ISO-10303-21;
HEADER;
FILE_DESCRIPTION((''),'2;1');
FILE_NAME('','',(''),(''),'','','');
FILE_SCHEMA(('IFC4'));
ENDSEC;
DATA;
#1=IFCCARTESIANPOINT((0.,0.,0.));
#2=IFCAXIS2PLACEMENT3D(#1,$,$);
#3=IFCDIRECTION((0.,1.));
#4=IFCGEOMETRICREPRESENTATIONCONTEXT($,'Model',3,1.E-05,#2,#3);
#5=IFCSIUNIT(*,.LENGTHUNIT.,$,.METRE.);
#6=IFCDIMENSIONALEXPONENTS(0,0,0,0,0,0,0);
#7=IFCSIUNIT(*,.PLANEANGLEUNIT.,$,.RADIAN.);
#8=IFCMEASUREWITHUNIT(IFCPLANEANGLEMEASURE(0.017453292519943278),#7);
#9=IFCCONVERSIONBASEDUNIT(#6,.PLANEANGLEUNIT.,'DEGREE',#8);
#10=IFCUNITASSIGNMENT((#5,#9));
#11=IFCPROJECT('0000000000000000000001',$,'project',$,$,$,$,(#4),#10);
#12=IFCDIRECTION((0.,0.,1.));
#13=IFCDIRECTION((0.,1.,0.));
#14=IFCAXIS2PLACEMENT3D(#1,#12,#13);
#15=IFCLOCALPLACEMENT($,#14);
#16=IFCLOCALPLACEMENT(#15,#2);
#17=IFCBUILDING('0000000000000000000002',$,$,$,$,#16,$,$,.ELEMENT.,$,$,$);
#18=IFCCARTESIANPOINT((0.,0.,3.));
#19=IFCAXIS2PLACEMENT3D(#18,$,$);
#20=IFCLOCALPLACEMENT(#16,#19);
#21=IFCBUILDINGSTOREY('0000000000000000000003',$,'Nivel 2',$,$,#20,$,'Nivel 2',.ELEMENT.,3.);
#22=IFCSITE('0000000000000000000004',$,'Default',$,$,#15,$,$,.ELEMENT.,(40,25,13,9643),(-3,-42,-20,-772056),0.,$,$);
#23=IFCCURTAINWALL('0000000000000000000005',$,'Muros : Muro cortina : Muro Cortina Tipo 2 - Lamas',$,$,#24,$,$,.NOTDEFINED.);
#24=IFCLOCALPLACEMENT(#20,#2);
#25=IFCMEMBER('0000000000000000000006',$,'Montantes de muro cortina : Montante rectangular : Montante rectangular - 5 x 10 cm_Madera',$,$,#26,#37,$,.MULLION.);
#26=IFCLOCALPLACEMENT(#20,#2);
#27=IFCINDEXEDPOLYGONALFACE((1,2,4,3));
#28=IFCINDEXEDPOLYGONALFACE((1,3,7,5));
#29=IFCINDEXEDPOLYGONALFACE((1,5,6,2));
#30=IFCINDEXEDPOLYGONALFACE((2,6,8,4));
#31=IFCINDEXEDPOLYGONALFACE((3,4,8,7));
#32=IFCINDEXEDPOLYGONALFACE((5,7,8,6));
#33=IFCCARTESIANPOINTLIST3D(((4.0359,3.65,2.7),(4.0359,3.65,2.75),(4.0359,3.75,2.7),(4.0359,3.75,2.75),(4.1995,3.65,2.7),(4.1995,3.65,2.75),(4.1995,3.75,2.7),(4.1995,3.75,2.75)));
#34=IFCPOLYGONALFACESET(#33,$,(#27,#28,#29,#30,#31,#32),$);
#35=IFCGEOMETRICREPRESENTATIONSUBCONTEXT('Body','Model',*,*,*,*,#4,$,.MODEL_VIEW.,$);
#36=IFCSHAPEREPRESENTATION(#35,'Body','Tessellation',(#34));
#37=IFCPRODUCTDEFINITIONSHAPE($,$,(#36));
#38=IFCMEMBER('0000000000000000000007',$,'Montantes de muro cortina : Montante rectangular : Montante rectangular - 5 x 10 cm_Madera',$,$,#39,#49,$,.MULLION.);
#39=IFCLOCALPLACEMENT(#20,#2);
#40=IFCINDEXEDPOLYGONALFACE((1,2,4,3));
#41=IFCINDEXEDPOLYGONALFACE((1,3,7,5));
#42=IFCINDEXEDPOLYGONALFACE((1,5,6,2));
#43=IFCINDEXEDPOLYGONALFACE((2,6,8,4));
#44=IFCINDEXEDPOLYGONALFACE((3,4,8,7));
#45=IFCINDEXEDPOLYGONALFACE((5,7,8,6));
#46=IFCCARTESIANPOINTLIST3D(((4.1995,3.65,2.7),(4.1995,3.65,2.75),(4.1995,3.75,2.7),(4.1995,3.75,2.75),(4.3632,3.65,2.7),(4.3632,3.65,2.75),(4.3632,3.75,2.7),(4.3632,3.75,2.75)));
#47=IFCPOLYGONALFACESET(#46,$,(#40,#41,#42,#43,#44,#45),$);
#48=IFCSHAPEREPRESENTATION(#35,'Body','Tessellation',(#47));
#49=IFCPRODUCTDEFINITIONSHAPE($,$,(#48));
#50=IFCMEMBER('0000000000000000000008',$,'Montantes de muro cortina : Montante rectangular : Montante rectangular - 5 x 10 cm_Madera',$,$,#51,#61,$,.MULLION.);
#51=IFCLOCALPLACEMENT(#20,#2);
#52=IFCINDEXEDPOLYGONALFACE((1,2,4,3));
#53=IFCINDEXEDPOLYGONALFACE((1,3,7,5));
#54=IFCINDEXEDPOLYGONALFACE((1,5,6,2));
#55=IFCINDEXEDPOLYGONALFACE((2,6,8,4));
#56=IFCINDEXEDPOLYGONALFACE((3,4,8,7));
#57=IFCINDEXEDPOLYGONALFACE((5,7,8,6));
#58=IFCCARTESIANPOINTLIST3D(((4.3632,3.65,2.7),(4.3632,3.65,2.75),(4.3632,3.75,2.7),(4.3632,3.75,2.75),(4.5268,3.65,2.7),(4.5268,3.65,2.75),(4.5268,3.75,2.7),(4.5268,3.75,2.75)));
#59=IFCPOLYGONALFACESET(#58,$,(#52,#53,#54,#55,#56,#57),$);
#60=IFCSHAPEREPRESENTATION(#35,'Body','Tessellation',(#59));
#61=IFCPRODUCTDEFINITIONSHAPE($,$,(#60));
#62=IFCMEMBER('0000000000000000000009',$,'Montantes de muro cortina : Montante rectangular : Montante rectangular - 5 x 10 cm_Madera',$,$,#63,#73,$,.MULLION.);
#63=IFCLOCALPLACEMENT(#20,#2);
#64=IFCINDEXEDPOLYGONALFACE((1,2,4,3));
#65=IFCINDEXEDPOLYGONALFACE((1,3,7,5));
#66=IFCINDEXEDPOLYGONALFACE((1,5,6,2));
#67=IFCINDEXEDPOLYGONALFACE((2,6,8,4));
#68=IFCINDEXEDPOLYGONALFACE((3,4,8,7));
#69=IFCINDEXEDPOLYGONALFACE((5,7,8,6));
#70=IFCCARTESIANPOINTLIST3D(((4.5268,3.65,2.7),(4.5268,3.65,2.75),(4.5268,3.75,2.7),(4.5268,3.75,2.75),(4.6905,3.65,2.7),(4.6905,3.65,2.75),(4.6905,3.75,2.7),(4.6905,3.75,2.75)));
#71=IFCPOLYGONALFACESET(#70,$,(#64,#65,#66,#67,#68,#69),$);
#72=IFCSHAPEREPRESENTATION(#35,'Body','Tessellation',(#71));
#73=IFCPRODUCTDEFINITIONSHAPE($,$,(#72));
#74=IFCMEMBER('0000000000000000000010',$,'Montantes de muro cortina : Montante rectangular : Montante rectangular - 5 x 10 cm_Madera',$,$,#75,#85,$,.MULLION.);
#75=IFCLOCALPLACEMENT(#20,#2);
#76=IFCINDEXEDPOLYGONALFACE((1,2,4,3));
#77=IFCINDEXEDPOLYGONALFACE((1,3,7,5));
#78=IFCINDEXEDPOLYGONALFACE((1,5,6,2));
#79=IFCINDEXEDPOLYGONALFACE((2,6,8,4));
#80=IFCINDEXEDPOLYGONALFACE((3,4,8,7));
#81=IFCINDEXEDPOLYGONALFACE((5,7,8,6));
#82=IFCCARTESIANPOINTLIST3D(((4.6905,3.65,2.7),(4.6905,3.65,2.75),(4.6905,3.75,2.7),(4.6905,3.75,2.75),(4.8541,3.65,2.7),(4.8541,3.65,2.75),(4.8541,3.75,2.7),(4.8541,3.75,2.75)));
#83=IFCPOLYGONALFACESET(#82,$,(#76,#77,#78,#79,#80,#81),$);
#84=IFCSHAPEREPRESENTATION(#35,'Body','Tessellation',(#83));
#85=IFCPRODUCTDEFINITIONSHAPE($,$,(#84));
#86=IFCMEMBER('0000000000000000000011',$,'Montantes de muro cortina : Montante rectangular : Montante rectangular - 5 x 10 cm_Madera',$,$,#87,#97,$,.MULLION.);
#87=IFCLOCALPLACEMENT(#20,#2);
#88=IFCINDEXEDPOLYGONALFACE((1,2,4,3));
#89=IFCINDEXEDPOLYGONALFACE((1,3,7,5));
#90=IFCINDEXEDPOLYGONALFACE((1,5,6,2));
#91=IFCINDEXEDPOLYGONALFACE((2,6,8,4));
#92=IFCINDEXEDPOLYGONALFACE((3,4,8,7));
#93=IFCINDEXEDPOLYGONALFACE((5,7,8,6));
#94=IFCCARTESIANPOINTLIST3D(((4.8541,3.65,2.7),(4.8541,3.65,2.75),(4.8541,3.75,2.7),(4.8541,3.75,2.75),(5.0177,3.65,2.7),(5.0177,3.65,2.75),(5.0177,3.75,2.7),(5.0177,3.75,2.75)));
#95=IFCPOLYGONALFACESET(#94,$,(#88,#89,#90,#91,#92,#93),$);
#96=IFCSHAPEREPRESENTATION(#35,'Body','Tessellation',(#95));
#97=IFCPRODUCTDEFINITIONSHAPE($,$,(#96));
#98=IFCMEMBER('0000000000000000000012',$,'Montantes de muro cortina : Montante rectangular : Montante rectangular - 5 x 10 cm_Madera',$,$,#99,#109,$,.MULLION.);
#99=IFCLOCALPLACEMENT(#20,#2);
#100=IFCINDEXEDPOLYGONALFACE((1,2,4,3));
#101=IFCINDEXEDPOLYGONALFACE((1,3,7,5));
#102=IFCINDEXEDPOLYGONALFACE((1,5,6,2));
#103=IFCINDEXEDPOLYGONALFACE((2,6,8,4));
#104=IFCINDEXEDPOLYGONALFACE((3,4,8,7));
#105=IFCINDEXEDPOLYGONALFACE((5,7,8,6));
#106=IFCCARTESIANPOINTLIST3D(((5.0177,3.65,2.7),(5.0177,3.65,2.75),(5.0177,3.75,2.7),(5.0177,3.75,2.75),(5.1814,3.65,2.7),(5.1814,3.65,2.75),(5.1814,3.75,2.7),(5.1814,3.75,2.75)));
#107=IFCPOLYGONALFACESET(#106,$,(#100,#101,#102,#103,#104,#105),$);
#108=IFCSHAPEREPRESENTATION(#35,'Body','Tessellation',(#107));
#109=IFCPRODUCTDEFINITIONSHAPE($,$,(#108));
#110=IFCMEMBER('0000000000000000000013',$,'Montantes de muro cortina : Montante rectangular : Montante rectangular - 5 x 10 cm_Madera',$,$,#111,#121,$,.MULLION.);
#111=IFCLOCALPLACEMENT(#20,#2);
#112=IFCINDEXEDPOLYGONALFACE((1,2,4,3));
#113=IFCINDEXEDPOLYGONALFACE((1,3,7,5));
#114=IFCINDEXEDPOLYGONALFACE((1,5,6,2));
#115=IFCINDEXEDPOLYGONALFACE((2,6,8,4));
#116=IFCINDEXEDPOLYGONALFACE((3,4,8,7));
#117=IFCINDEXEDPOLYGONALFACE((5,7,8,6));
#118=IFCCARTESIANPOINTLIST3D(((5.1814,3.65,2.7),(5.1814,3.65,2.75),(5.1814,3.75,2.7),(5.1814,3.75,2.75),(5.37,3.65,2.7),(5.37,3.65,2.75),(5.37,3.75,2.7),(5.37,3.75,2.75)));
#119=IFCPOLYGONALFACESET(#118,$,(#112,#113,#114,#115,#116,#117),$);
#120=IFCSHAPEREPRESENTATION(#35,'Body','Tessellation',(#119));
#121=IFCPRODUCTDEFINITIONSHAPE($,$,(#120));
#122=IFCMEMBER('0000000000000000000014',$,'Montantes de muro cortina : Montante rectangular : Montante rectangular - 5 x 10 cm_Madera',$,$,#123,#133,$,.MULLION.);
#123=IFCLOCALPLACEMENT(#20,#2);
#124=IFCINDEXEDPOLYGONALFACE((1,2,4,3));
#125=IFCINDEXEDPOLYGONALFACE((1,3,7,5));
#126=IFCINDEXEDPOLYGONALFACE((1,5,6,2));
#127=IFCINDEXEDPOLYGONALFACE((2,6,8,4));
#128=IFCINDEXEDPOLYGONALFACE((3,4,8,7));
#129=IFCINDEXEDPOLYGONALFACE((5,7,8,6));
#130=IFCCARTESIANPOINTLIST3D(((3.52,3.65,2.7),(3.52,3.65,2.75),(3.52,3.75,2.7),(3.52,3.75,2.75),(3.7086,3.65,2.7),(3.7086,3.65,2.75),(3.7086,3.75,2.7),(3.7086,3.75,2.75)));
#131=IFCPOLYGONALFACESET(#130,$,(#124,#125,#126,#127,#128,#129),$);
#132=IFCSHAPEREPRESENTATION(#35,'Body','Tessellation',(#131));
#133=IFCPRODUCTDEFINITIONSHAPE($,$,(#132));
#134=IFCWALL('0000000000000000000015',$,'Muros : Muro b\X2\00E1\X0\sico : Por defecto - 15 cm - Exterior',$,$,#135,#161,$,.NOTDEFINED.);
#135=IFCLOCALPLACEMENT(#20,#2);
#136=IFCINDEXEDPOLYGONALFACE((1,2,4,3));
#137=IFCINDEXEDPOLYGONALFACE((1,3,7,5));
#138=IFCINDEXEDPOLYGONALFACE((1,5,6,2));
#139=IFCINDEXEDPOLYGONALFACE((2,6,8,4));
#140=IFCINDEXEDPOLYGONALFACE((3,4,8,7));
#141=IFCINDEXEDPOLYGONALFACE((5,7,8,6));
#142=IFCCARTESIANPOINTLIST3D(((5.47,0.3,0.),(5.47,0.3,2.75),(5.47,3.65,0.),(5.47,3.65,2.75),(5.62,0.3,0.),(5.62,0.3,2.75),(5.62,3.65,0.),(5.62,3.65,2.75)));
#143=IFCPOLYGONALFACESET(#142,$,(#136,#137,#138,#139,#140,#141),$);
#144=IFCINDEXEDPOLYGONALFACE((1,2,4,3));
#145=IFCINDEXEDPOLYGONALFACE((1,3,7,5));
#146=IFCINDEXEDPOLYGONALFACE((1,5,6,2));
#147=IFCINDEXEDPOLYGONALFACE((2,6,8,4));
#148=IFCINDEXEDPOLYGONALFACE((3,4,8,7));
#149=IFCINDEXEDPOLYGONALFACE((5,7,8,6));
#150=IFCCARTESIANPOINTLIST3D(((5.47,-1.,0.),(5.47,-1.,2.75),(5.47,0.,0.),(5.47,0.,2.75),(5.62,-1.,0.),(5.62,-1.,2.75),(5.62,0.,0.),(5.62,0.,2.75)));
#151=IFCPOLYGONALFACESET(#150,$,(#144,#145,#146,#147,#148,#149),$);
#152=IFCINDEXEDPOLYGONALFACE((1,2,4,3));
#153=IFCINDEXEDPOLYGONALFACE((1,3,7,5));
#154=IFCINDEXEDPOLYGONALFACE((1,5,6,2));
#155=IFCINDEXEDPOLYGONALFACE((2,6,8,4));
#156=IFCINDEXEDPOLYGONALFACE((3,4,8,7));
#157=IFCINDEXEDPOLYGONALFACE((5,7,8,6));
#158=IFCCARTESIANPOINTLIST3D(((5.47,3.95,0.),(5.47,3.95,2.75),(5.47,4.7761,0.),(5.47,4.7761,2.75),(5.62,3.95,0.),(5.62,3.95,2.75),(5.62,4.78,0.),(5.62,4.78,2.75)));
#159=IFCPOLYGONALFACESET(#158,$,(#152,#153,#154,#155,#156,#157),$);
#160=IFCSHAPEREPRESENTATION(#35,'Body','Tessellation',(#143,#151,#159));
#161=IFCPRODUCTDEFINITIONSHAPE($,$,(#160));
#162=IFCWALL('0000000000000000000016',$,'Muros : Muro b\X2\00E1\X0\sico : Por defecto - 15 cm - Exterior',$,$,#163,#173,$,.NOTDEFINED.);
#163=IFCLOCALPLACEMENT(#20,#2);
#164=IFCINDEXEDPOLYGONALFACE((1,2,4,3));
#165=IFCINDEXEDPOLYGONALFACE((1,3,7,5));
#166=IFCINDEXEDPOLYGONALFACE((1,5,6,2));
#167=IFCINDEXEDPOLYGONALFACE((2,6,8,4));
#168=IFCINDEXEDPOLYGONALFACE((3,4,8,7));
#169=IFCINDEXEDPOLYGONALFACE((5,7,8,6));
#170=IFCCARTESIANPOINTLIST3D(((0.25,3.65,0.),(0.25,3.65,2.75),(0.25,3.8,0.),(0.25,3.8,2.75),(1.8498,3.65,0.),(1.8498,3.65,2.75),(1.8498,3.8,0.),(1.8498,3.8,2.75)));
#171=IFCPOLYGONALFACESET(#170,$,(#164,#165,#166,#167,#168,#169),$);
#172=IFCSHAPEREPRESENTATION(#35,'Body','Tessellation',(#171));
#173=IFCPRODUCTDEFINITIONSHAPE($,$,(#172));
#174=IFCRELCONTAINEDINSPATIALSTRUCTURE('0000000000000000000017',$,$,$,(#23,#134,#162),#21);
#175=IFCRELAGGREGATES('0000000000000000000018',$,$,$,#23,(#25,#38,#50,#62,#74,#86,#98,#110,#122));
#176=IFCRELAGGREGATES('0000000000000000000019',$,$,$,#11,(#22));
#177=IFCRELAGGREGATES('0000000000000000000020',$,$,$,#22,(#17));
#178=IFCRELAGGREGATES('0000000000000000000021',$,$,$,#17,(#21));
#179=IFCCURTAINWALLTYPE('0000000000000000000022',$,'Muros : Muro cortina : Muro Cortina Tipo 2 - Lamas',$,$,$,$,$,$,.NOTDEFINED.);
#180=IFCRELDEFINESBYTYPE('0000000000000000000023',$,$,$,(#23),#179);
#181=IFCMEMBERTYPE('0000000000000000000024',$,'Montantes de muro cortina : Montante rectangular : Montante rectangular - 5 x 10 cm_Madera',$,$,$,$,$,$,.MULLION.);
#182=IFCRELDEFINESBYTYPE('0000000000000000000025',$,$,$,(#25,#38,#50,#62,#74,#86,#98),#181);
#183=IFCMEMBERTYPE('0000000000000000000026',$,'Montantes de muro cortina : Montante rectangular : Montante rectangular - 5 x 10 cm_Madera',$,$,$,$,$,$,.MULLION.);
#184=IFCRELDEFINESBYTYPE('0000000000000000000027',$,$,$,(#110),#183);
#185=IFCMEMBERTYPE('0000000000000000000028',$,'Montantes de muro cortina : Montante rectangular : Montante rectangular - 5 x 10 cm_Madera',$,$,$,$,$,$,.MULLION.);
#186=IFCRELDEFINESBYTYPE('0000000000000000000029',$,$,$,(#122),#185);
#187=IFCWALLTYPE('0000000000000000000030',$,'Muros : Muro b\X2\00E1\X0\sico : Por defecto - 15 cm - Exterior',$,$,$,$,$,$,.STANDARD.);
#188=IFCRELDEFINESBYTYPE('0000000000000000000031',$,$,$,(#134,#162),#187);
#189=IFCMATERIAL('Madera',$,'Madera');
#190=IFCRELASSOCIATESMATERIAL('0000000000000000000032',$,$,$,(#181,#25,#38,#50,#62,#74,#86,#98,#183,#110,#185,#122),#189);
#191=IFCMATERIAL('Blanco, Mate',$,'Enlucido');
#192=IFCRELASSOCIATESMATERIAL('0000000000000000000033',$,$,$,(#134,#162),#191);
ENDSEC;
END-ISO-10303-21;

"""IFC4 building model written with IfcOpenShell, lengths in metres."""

from ifc_helpers import new_model, entity, si_unit, converted_unit, direction, frame, origin, place, context, subcontext, project, spatial, indexed_curve, outline, extrude, source, transform, mapped, material, type_object, type_shapes, element, aggregate, save


model = new_model("IFC4")

# Units and contexts
model_context = context("Model", 3, precision=1e-05, world=origin(), true_north=direction((0.0, 1.0)))
body_context = subcontext(model_context, "Body", "Model", "MODEL_VIEW")
ifc_project = project(units=[si_unit("LENGTHUNIT", "METRE"), converted_unit("PLANEANGLEUNIT", "DEGREE", entity("IfcPlaneAngleMeasure", 0.017453292519943278), si_unit("PLANEANGLEUNIT", "RADIAN"), dimensions=[0, 0, 0, 0, 0, 0, 0])], contexts=[model_context])

# Site, building, storey
site_placement = place(None, frame((0.0, 0.0, 0.0), z_axis=(0.0, 0.0, 1.0), x_axis=(0.0, 1.0, 0.0)))
site = spatial("IfcSite", under=ifc_project, at=site_placement, Name="Default", CompositionType="ELEMENT", RefLatitude=(40, 25, 13, 9643), RefLongitude=(-3, -42, -20, -772056), RefElevation=0.0)
building_placement = place(site_placement, origin())
building = spatial("IfcBuilding", under=site, at=building_placement, CompositionType="ELEMENT")
storey_placement = place(building_placement, frame((0.0, 0.0, 3.0)))
storey = spatial("IfcBuildingStorey", under=building, at=storey_placement, Name="Nivel 2", LongName="Nivel 2", CompositionType="ELEMENT", Elevation=3.0)

# Curtain wall, members
curtain_wall_type = type_object("IfcCurtainWallType", Name="Muros : Muro cortina : Muro Cortina Tipo 2 - Lamas", PredefinedType="NOTDEFINED")
curtain_wall_placement = place(storey_placement, frame((0.0, 0.0, -3.0)))
curtain_wall = element("IfcCurtainWall", 1, at=curtain_wall_placement, inside=storey, type_object=curtain_wall_type, Name="Muros : Muro cortina : Muro Cortina Tipo 2 - Lamas", PredefinedType="NOTDEFINED")
ifc_material_1 = material(Name="Madera", Category="Madera")
member_type_1 = type_object("IfcMemberType", Name="Montantes de muro cortina : Montante rectangular : Montante rectangular - 5 x 10 cm_Madera", PredefinedType="MULLION", material=ifc_material_1)
shared_shape_1 = source(origin(), body_context, "Body", "SweptSolid", [
    extrude(outline(indexed_curve([(-0.025, -0.05), (0.025, -0.05), (0.025, 0.05), (-0.025, 0.05), (-0.025, -0.05)], self_intersect=False)), frame((-0.025, 0.0, -0.1636), z_axis=(0.0, 0.0, 1.0), x_axis=(-1.0, 0.0, 0.0)), (0.0, 0.0, 1.0), 0.1636),
])
type_shapes(member_type_1, [shared_shape_1])
member_1_placement = place(curtain_wall_placement, frame((4.0359, 3.7, 5.75), z_axis=(-1.0, 0.0, 0.0), x_axis=(0.0, 0.0, 1.0)))
member_1 = element("IfcMember", 2, at=member_1_placement, type_object=member_type_1, material=ifc_material_1, Name="Montantes de muro cortina : Montante rectangular : Montante rectangular - 5 x 10 cm_Madera", PredefinedType="MULLION", context=body_context, shape_type="MappedRepresentation", body=[
    mapped(shared_shape_1, transform((0.0, 0.0, 0.0), scale=1.0)),
])
member_2_placement = place(curtain_wall_placement, frame((4.1995, 3.7, 5.75), z_axis=(-1.0, 0.0, 0.0), x_axis=(0.0, 0.0, 1.0)))
member_2 = element("IfcMember", 3, at=member_2_placement, type_object=member_type_1, material=ifc_material_1, Name="Montantes de muro cortina : Montante rectangular : Montante rectangular - 5 x 10 cm_Madera", PredefinedType="MULLION", context=body_context, shape_type="MappedRepresentation", body=[
    mapped(shared_shape_1, transform((0.0, 0.0, 0.0), scale=1.0)),
])
member_3_placement = place(curtain_wall_placement, frame((4.3632, 3.7, 5.75), z_axis=(-1.0, 0.0, 0.0), x_axis=(0.0, 0.0, 1.0)))
member_3 = element("IfcMember", 4, at=member_3_placement, type_object=member_type_1, material=ifc_material_1, Name="Montantes de muro cortina : Montante rectangular : Montante rectangular - 5 x 10 cm_Madera", PredefinedType="MULLION", context=body_context, shape_type="MappedRepresentation", body=[
    mapped(shared_shape_1, transform((0.0, 0.0, 0.0), scale=1.0)),
])
member_4_placement = place(curtain_wall_placement, frame((4.5268, 3.7, 5.75), z_axis=(-1.0, 0.0, 0.0), x_axis=(0.0, 0.0, 1.0)))
member_4 = element("IfcMember", 5, at=member_4_placement, type_object=member_type_1, material=ifc_material_1, Name="Montantes de muro cortina : Montante rectangular : Montante rectangular - 5 x 10 cm_Madera", PredefinedType="MULLION", context=body_context, shape_type="MappedRepresentation", body=[
    mapped(shared_shape_1, transform((0.0, 0.0, 0.0), scale=1.0)),
])
member_5_placement = place(curtain_wall_placement, frame((4.6905, 3.7, 5.75), z_axis=(-1.0, 0.0, 0.0), x_axis=(0.0, 0.0, 1.0)))
member_5 = element("IfcMember", 6, at=member_5_placement, type_object=member_type_1, material=ifc_material_1, Name="Montantes de muro cortina : Montante rectangular : Montante rectangular - 5 x 10 cm_Madera", PredefinedType="MULLION", context=body_context, shape_type="MappedRepresentation", body=[
    mapped(shared_shape_1, transform((0.0, 0.0, 0.0), scale=1.0)),
])
member_6_placement = place(curtain_wall_placement, frame((4.8541, 3.7, 5.75), z_axis=(-1.0, 0.0, 0.0), x_axis=(0.0, 0.0, 1.0)))
member_6 = element("IfcMember", 7, at=member_6_placement, type_object=member_type_1, material=ifc_material_1, Name="Montantes de muro cortina : Montante rectangular : Montante rectangular - 5 x 10 cm_Madera", PredefinedType="MULLION", context=body_context, shape_type="MappedRepresentation", body=[
    mapped(shared_shape_1, transform((0.0, 0.0, 0.0), scale=1.0)),
])
member_7_placement = place(curtain_wall_placement, frame((5.0177, 3.7, 5.75), z_axis=(-1.0, 0.0, 0.0), x_axis=(0.0, 0.0, 1.0)))
member_7 = element("IfcMember", 8, at=member_7_placement, type_object=member_type_1, material=ifc_material_1, Name="Montantes de muro cortina : Montante rectangular : Montante rectangular - 5 x 10 cm_Madera", PredefinedType="MULLION", context=body_context, shape_type="MappedRepresentation", body=[
    mapped(shared_shape_1, transform((0.0, 0.0, 0.0), scale=1.0)),
])
member_type_2 = type_object("IfcMemberType", Name="Montantes de muro cortina : Montante rectangular : Montante rectangular - 5 x 10 cm_Madera", PredefinedType="MULLION", material=ifc_material_1)
shared_shape_2 = source(origin(), body_context, "Body", "SweptSolid", [
    extrude(outline(indexed_curve([(-0.025, -0.05), (0.025, -0.05), (0.025, 0.05), (-0.025, 0.05), (-0.025, -0.05)], self_intersect=False)), frame((-0.025, 0.0, -0.1886), z_axis=(0.0, 0.0, 1.0), x_axis=(-1.0, 0.0, 0.0)), (0.0, 0.0, 1.0), 0.1886),
])
type_shapes(member_type_2, [shared_shape_2])
member_8_placement = place(curtain_wall_placement, frame((5.1814, 3.7, 5.75), z_axis=(-1.0, 0.0, 0.0), x_axis=(0.0, 0.0, 1.0)))
member_8 = element("IfcMember", 9, at=member_8_placement, type_object=member_type_2, material=ifc_material_1, Name="Montantes de muro cortina : Montante rectangular : Montante rectangular - 5 x 10 cm_Madera", PredefinedType="MULLION", context=body_context, shape_type="MappedRepresentation", body=[
    mapped(shared_shape_2, transform((0.0, 0.0, 0.0), scale=1.0)),
])
member_type_3 = type_object("IfcMemberType", Name="Montantes de muro cortina : Montante rectangular : Montante rectangular - 5 x 10 cm_Madera", PredefinedType="MULLION", material=ifc_material_1)
shared_shape_3 = source(origin(), body_context, "Body", "SweptSolid", [
    extrude(outline(indexed_curve([(-0.025, -0.05), (0.025, -0.05), (0.025, 0.05), (-0.025, 0.05), (-0.025, -0.05)], self_intersect=False)), frame((-0.025, 0.0, -0.1886), z_axis=(0.0, 0.0, 1.0), x_axis=(-1.0, 0.0, 0.0)), (0.0, 0.0, 1.0), 0.1886),
])
type_shapes(member_type_3, [shared_shape_3])
member_9_placement = place(curtain_wall_placement, frame((3.52, 3.7, 5.75), z_axis=(-1.0, 0.0, 0.0), x_axis=(0.0, 0.0, 1.0)))
member_9 = element("IfcMember", 10, at=member_9_placement, type_object=member_type_3, material=ifc_material_1, Name="Montantes de muro cortina : Montante rectangular : Montante rectangular - 5 x 10 cm_Madera", PredefinedType="MULLION", context=body_context, shape_type="MappedRepresentation", body=[
    mapped(shared_shape_3, transform((0.0, 0.0, 0.0), scale=1.0)),
])
aggregate(curtain_wall, [member_1, member_2, member_3, member_4, member_5, member_6, member_7, member_8, member_9])

# Walls
ifc_material_2 = material(Name="Blanco, Mate", Category="Enlucido")
wall_type_1 = type_object("IfcWallType", Name="Muros : Muro básico : Por defecto - 15 cm - Exterior", PredefinedType="STANDARD")
wall_1_placement = place(storey_placement, frame((5.545, 4.78, 0.0), z_axis=(0.0, 0.0, 1.0), x_axis=(0.0, -1.0, 0.0)))
element("IfcWall", 11, at=wall_1_placement, inside=storey, type_object=wall_type_1, material=ifc_material_2, Name="Muros : Muro básico : Por defecto - 15 cm - Exterior", PredefinedType="NOTDEFINED", context=body_context, shape_type="SweptSolid", body=[
    extrude(outline(indexed_curve([(-0.075, -1.675), (0.075, -1.675), (0.075, 1.675), (-0.075, 1.675), (-0.075, -1.675)], self_intersect=False)), frame((2.805, 0.0, 0.0), z_axis=(0.0, 0.0, 1.0), x_axis=(0.0, 1.0, 0.0)), (0.0, 0.0, 1.0), 2.75),
    extrude(outline(indexed_curve([(-0.075, -0.5), (0.075, -0.5), (0.075, 0.5), (-0.075, 0.5), (-0.075, -0.5)], self_intersect=False)), frame((5.28, 0.0, 0.0), z_axis=(0.0, 0.0, 1.0), x_axis=(0.0, 1.0, 0.0)), (0.0, 0.0, 1.0), 2.75),
    extrude(outline(indexed_curve([(-0.075, -0.414), (0.075, -0.414), (0.075, 0.416), (-0.075, 0.4121), (-0.075, -0.414)], self_intersect=False)), frame((0.416, 0.0, 0.0), z_axis=(0.0, 0.0, 1.0), x_axis=(0.0, 1.0, 0.0)), (0.0, 0.0, 1.0), 2.75),
])
wall_2_placement = place(storey_placement, frame((0.25, 3.725, 0.0)))
element("IfcWall", 12, at=wall_2_placement, inside=storey, type_object=wall_type_1, material=ifc_material_2, Name="Muros : Muro básico : Por defecto - 15 cm - Exterior", PredefinedType="NOTDEFINED", context=body_context, shape_type="SweptSolid", body=[
    extrude(outline(indexed_curve([(1.5998, 0.075), (0.0, 0.075), (0.0, -0.075), (1.5998, -0.075), (1.5998, 0.075)], self_intersect=False)), origin(), (0.0, 0.0, 1.0), 2.75),
])

save(model, "model.ifc")
